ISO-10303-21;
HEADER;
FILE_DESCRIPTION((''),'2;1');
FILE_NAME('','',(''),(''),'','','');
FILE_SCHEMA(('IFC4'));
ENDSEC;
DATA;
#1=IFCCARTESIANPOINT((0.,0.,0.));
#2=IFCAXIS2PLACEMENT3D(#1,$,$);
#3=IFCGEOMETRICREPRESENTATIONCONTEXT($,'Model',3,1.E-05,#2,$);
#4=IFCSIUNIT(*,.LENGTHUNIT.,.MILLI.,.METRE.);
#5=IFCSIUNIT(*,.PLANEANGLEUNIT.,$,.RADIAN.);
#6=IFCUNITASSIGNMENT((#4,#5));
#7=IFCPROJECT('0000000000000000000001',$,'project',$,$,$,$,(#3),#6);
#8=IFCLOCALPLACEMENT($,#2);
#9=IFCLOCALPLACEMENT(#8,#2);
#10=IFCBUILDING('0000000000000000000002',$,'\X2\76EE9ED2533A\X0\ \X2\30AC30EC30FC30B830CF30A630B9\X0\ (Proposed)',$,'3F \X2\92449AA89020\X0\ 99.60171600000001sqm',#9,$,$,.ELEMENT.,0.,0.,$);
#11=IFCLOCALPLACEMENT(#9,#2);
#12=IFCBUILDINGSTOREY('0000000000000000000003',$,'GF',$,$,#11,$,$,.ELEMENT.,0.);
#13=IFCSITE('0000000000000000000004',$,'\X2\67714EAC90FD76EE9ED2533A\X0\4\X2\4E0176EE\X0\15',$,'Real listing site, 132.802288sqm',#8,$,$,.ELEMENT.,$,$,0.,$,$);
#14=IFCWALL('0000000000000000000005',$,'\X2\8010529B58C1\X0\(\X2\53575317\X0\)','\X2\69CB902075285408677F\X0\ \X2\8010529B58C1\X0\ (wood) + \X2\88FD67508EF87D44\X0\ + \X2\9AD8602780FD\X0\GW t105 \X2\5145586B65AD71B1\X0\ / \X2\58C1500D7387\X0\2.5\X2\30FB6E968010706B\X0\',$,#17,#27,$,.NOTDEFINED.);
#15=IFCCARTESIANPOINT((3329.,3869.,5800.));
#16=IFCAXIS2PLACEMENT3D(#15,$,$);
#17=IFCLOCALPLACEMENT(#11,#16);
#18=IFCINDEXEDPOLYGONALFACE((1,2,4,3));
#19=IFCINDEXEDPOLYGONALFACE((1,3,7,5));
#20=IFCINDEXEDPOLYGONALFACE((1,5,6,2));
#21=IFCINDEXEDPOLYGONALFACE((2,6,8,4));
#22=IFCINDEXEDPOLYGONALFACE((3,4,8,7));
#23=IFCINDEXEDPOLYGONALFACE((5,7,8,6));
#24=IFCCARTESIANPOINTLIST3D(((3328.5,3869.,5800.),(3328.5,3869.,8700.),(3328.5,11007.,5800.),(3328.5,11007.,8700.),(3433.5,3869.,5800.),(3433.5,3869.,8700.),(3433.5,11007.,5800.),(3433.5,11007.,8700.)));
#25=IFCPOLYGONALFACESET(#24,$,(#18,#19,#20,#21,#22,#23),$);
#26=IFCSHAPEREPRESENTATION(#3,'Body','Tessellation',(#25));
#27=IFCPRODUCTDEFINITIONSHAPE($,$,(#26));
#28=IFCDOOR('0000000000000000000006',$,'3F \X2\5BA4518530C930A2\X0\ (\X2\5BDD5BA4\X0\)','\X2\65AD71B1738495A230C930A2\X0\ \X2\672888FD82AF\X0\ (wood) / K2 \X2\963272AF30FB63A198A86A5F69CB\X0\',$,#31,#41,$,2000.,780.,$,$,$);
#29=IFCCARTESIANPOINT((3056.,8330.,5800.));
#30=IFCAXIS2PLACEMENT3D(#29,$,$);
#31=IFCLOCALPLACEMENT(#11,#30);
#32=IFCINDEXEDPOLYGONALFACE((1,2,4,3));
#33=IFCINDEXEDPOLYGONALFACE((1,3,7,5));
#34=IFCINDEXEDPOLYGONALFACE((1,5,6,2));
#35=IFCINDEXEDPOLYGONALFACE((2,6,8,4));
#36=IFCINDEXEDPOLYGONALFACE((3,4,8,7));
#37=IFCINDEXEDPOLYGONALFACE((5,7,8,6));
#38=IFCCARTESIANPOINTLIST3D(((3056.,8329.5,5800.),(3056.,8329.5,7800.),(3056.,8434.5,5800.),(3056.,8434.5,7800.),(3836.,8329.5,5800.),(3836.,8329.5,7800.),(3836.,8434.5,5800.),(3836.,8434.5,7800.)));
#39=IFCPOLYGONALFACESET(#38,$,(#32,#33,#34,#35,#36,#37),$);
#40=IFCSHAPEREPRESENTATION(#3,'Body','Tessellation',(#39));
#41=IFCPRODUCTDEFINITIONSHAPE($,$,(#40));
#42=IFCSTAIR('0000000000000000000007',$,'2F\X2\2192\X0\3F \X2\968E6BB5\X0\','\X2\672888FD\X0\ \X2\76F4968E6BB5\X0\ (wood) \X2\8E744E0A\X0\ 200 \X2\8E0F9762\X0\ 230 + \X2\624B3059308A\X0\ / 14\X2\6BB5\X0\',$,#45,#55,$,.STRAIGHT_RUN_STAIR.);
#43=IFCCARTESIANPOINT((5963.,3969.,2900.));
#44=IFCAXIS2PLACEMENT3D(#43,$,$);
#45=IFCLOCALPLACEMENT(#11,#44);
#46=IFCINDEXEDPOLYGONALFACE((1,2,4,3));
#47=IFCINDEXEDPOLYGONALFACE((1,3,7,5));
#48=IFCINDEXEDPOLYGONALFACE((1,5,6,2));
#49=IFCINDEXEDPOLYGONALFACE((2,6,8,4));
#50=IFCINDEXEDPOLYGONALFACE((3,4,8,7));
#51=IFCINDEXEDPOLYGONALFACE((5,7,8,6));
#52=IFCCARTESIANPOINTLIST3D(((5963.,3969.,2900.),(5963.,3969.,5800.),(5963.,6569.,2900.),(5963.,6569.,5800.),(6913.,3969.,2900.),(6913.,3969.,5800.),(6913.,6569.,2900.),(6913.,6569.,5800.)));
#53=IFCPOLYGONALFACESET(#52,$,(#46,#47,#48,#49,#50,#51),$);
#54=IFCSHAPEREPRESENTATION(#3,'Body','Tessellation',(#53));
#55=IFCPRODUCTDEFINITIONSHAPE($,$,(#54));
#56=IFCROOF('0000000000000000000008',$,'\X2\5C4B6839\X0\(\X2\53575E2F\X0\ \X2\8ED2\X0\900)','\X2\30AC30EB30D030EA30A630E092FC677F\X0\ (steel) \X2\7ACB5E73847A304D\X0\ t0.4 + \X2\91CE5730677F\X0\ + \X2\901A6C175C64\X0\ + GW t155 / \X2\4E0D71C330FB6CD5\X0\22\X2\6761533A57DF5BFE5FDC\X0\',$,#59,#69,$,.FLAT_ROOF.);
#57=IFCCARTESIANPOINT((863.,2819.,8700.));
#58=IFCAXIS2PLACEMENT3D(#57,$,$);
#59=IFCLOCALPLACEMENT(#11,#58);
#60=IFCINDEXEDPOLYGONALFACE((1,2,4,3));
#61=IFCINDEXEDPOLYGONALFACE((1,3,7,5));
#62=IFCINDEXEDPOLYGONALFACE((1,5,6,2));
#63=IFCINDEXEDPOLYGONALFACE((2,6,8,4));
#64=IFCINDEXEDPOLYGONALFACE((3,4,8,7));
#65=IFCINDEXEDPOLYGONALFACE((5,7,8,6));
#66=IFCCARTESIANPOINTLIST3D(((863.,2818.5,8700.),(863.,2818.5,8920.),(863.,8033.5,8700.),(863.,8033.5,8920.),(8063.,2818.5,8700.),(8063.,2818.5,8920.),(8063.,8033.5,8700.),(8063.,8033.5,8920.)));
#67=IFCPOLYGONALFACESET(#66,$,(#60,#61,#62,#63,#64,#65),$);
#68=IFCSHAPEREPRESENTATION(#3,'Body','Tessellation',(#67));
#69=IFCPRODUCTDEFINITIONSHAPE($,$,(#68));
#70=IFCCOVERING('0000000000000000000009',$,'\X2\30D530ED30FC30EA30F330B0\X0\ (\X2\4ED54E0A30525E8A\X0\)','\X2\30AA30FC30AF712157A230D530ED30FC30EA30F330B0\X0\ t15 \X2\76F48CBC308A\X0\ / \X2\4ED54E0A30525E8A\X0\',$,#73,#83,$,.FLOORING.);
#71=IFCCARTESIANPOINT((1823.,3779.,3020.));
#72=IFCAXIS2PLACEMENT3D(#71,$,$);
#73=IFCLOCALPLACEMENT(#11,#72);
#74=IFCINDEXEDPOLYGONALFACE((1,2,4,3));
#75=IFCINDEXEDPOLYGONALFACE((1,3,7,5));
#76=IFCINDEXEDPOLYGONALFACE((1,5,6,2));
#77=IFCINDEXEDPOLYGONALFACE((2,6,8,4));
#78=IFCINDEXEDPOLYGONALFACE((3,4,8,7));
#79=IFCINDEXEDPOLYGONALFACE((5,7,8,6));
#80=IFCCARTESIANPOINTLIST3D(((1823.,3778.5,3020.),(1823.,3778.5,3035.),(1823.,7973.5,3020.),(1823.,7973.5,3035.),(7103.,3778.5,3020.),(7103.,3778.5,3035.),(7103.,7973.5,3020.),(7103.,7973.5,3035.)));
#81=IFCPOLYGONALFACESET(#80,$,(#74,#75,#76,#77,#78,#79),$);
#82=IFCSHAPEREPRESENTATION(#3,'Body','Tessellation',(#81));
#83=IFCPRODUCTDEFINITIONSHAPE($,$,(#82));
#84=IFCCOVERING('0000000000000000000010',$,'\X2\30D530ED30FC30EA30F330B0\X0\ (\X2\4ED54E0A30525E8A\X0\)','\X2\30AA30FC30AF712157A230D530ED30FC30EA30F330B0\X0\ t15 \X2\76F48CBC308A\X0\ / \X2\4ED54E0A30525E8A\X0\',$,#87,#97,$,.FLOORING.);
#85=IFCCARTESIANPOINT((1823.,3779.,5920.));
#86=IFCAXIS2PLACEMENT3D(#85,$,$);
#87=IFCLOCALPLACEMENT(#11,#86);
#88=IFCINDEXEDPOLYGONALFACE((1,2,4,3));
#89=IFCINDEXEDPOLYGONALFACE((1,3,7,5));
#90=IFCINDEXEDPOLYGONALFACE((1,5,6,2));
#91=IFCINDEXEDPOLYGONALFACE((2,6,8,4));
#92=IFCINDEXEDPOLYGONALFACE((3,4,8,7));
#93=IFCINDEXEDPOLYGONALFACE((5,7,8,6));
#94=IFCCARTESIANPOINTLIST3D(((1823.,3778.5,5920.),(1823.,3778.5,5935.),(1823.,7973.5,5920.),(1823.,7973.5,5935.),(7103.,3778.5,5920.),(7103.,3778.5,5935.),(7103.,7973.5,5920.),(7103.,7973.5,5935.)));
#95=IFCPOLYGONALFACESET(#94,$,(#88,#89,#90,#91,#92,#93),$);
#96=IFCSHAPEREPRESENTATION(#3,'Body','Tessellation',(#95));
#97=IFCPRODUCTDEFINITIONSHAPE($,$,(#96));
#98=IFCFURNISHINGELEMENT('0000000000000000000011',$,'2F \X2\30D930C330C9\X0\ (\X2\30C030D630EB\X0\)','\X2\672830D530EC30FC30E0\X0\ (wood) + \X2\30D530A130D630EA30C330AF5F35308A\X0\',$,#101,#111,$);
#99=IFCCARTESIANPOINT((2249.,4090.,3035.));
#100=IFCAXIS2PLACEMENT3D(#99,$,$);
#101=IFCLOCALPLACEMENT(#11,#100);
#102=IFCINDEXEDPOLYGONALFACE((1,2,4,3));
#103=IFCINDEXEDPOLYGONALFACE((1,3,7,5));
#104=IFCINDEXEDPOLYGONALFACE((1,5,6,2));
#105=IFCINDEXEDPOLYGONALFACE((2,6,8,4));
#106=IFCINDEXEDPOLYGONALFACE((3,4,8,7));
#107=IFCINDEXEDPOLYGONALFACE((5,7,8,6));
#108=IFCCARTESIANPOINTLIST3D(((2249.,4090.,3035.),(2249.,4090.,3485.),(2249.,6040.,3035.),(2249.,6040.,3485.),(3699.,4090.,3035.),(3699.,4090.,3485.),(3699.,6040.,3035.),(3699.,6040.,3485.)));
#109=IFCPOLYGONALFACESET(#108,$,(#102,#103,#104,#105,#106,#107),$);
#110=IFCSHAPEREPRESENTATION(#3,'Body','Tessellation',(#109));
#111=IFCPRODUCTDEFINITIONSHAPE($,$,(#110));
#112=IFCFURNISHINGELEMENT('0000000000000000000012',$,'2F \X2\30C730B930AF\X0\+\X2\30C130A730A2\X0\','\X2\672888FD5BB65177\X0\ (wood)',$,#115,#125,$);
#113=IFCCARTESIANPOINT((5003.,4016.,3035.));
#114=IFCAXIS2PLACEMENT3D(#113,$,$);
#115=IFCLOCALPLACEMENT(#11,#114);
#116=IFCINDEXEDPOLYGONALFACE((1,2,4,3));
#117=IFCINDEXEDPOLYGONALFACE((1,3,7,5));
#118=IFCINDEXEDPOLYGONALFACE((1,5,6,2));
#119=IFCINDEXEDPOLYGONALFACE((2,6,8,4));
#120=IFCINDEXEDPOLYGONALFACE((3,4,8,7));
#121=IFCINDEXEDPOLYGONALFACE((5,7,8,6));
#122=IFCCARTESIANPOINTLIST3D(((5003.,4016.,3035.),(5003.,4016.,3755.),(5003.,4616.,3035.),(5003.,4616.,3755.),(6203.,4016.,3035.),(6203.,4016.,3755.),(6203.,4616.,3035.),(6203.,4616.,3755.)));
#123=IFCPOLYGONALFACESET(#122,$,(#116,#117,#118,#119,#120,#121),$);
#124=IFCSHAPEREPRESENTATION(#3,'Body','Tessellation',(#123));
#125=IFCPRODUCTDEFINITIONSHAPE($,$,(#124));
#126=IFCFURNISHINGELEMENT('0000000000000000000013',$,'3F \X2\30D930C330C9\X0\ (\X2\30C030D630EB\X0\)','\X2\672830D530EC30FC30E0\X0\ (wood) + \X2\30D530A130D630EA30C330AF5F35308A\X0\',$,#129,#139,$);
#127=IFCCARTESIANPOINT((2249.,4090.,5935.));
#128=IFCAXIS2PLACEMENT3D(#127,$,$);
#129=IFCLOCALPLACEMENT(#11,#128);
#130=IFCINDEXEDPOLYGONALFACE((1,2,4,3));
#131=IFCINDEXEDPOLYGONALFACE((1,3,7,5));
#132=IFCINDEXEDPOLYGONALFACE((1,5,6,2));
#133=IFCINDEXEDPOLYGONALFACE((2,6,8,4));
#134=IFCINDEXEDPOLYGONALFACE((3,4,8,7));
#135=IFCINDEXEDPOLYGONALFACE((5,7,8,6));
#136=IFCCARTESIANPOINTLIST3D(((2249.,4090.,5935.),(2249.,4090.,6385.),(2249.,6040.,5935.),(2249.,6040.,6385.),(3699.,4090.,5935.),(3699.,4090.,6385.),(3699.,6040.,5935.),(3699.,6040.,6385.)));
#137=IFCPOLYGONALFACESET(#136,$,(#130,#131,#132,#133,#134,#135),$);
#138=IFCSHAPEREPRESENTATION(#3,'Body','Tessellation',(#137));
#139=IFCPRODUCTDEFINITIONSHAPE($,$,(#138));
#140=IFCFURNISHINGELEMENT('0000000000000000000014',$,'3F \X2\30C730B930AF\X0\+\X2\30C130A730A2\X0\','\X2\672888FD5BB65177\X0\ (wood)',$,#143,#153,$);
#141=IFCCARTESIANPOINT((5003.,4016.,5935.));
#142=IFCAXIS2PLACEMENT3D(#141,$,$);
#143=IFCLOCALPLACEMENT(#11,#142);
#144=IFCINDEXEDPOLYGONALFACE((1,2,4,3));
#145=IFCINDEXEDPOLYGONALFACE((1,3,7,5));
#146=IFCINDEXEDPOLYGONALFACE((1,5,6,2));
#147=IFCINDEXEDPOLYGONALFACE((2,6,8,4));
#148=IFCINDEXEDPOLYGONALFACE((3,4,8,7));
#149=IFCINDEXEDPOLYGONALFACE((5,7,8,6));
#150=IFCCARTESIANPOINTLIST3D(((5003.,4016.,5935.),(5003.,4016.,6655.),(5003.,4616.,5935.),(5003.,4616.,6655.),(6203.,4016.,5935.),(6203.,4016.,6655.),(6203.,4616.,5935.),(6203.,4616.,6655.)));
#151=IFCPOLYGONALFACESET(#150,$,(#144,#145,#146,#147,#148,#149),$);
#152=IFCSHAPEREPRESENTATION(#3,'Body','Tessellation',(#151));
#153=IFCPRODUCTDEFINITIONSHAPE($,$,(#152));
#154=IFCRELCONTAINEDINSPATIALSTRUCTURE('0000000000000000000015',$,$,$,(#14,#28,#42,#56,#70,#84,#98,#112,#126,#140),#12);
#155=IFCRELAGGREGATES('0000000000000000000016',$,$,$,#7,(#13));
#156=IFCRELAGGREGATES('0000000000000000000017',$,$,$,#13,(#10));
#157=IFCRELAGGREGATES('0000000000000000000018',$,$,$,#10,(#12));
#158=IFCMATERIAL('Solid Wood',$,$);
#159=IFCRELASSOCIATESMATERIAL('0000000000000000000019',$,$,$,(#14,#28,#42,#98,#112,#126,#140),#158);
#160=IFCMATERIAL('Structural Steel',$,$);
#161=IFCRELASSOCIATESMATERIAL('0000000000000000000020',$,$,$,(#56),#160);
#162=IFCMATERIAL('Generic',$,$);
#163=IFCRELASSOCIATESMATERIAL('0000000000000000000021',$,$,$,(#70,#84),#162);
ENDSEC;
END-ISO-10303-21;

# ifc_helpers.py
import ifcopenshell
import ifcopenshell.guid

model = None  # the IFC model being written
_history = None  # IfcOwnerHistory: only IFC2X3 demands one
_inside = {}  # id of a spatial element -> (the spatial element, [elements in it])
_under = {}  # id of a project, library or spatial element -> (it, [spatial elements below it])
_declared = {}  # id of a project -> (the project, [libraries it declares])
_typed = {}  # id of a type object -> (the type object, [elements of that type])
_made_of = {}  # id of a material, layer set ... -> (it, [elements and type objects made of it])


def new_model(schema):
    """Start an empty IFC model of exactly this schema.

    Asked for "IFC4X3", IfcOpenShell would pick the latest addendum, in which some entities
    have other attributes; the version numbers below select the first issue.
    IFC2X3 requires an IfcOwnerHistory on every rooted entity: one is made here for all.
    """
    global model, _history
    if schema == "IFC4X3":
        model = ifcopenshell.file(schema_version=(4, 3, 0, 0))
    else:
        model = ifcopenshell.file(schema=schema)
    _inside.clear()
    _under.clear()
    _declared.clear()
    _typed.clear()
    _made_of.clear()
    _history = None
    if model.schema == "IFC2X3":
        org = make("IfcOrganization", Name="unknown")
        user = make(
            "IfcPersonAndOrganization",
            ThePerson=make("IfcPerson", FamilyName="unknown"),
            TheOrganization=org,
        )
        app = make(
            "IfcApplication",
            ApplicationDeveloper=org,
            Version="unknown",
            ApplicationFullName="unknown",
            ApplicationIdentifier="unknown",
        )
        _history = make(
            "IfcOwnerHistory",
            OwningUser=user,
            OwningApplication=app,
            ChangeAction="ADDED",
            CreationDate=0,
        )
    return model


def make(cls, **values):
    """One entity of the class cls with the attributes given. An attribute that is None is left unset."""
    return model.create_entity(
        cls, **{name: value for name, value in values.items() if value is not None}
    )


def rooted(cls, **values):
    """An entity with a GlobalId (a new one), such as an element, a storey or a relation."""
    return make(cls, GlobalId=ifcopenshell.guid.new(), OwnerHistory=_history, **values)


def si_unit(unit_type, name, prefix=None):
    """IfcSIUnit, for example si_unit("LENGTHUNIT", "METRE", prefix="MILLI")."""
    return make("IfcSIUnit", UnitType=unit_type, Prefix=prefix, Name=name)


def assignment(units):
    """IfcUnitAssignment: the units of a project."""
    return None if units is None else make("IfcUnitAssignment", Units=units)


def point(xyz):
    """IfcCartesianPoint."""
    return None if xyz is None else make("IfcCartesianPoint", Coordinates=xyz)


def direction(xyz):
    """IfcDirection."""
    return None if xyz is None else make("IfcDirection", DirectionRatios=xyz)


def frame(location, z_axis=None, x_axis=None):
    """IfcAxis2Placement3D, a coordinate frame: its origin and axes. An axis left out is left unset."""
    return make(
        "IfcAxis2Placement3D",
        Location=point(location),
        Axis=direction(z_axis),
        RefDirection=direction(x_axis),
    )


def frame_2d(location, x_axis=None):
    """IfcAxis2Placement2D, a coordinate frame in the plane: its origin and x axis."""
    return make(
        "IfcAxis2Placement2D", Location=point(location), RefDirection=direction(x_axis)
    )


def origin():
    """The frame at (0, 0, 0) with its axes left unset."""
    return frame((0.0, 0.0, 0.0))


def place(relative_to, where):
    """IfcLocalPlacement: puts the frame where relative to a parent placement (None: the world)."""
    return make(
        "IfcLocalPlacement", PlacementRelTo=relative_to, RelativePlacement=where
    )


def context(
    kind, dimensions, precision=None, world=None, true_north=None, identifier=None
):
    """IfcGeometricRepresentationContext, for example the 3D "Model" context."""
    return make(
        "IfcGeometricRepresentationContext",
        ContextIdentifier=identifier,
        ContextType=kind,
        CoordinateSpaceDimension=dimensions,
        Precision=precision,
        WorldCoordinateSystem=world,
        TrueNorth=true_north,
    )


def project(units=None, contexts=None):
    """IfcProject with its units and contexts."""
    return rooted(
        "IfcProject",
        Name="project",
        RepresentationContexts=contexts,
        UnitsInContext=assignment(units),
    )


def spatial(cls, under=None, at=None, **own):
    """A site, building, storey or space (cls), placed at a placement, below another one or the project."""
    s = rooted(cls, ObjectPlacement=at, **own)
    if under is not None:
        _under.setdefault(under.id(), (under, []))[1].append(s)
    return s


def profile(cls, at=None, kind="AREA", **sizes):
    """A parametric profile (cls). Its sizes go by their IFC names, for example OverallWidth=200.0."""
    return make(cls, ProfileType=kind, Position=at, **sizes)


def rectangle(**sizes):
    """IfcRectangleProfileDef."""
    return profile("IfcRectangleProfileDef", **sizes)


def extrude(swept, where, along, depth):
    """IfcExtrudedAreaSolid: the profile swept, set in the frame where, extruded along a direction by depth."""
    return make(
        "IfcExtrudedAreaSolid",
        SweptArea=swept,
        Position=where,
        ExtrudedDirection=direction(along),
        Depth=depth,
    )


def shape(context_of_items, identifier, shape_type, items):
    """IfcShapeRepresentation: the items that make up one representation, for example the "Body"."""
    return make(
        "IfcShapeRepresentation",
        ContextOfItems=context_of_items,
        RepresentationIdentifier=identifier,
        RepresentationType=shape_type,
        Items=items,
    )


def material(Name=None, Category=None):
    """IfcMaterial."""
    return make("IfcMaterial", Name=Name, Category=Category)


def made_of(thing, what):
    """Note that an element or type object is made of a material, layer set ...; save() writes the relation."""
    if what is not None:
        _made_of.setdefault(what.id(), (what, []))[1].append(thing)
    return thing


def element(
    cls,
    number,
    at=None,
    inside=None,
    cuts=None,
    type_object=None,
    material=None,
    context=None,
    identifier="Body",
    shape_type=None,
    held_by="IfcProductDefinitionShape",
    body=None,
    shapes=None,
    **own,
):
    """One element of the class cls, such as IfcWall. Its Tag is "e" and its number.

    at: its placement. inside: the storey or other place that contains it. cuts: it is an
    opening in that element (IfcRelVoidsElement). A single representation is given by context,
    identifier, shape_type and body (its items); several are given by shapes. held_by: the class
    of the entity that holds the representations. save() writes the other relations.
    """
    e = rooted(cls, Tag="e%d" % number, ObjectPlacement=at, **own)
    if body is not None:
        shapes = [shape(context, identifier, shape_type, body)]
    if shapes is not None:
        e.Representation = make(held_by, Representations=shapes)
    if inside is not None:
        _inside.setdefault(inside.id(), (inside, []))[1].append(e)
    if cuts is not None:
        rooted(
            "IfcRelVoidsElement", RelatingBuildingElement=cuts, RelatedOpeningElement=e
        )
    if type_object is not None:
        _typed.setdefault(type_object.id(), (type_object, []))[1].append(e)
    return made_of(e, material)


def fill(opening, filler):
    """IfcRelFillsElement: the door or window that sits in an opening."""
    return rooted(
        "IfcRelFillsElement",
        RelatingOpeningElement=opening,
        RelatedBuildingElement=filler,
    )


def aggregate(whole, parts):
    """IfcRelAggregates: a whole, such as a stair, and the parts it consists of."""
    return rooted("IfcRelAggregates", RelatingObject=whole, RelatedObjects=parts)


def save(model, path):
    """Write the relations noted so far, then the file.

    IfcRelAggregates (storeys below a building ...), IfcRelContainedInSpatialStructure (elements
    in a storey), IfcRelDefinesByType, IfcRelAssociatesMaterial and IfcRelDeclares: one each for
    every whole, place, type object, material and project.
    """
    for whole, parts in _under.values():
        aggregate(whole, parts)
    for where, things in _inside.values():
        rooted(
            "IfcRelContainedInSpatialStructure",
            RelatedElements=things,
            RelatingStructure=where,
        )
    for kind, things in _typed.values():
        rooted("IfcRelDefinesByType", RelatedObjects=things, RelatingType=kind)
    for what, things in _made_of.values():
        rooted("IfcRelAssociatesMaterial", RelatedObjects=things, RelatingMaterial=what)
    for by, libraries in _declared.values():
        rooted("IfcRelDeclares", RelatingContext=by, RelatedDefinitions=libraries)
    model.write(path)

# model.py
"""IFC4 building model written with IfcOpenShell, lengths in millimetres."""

from ifc_helpers import new_model, si_unit, frame, frame_2d, origin, place, context, project, spatial, rectangle, extrude, material, element, fill, save


model = new_model("IFC4")

# Units and contexts
model_context = context("Model", 3, precision=1e-05, world=origin())
ifc_project = project(units=[si_unit("LENGTHUNIT", "METRE", prefix="MILLI"), si_unit("PLANEANGLEUNIT", "RADIAN")], contexts=[model_context])

# Site, building, storey
site_placement = place(None, origin())
site = spatial("IfcSite", under=ifc_project, at=site_placement, Name="東京都目黒区4丁目15", ObjectType="Real listing site, 132.802288sqm", CompositionType="ELEMENT", RefElevation=0.0)
building_placement = place(site_placement, origin())
building = spatial("IfcBuilding", under=site, at=building_placement, Name="目黒区 ガレージハウス (Proposed)", ObjectType="3F 鉄骨造 99.60171600000001sqm", CompositionType="ELEMENT", ElevationOfRefHeight=0.0, ElevationOfTerrain=0.0)
storey_placement = place(building_placement, origin())
storey = spatial("IfcBuildingStorey", under=building, at=storey_placement, Name="GF", CompositionType="ELEMENT", Elevation=0.0)

# Shared definitions
ifc_material_1 = material(Name="Solid Wood")

# Wall, opening, door
wall_1_placement = place(storey_placement, frame((3329.0, 3869.0, 5800.0)))
wall_1 = element("IfcWall", 1, at=wall_1_placement, inside=storey, material=ifc_material_1, Name="耐力壁(南北)", Description="構造用合板 耐力壁 (wood) + 製材軸組 + 高性能GW t105 充填断熱 / 壁倍率2.5・準耐火", PredefinedType="NOTDEFINED", context=model_context, shape_type="SweptSolid", body=[
    extrude(rectangle(XDim=105.0, YDim=7138.0, at=frame_2d((52.0, 3569.0))), frame((3329.0, 3869.0, 5800.0)), (0.0, 0.0, 1.0), 2900.0),
])
opening_1_placement = place(storey_placement, frame((3056.0, 8330.0, 5800.0)))
opening_1 = element("IfcOpeningElement", 2, at=opening_1_placement, cuts=wall_1, PredefinedType="NOTDEFINED", context=model_context, shape_type="SweptSolid", body=[
    extrude(rectangle(XDim=780.0, YDim=105.0, at=frame_2d((390.0, 52.0))), frame((3056.0, 8330.0, 5800.0)), (0.0, 0.0, 1.0), 2000.0),
])
door_1_placement = place(storey_placement, frame((3056.0, 8330.0, 5800.0)))
door_1 = element("IfcDoor", 3, at=door_1_placement, inside=storey, material=ifc_material_1, Name="3F 室内ドア (寝室)", Description="断熱玄関ドア 木製芯 (wood) / K2 防犯・採風機構", OverallHeight=2000.0, OverallWidth=780.0, context=model_context, shape_type="SweptSolid", body=[
    extrude(rectangle(XDim=780.0, YDim=105.0, at=frame_2d((390.0, 52.0))), frame((3056.0, 8330.0, 5800.0)), (0.0, 0.0, 1.0), 2000.0),
])
fill(opening_1, door_1)

# Stair
stair_placement = place(storey_placement, frame((5963.0, 3969.0, 2900.0)))
element("IfcStair", 4, at=stair_placement, inside=storey, material=ifc_material_1, Name="2F→3F 階段", Description="木製 直階段 (wood) 蹴上 200 踏面 230 + 手すり / 14段", PredefinedType="STRAIGHT_RUN_STAIR", context=model_context, shape_type="SweptSolid", body=[
    extrude(rectangle(XDim=950.0, YDim=2600.0, at=frame_2d((475.0, 1300.0))), frame((5963.0, 3969.0, 2900.0)), (0.0, 0.0, 1.0), 2900.0),
])

# Roof
ifc_material_2 = material(Name="Structural Steel")
for number, where, name in (
    (5, (863.0, 2819.0, 8700.0), "屋根(南帯 軒900)"),
):
    element("IfcRoof", number, at=place(storey_placement, frame(where)), inside=storey, material=ifc_material_2, Name=name, Description="ガルバリウム鋼板 (steel) 立平葺き t0.4 + 野地板 + 通気層 + GW t155 / 不燃・法22条区域対応", PredefinedType="FLAT_ROOF", context=model_context, shape_type="SweptSolid", body=[
        extrude(rectangle(XDim=7200.0, YDim=5215.0, at=frame_2d((3600.0, 2607.0))), frame((863.0, 2819.0, 8700.0)), (0.0, 0.0, 1.0), 220.0),
    ])

# Coverings
ifc_material_3 = material(Name="Generic")
covering_1_placement = place(storey_placement, frame((1823.0, 3779.0, 3020.0)))
element("IfcCovering", 6, at=covering_1_placement, inside=storey, material=ifc_material_3, Name="フローリング (仕上げ床)", Description="オーク無垢フローリング t15 直貼り / 仕上げ床", PredefinedType="FLOORING", context=model_context, shape_type="SweptSolid", body=[
    extrude(rectangle(XDim=5280.0, YDim=4195.0, at=frame_2d((2640.0, 2097.0))), frame((1823.0, 3779.0, 3020.0)), (0.0, 0.0, 1.0), 15.0),
])
covering_2_placement = place(storey_placement, frame((1823.0, 3779.0, 5920.0)))
element("IfcCovering", 7, at=covering_2_placement, inside=storey, material=ifc_material_3, Name="フローリング (仕上げ床)", Description="オーク無垢フローリング t15 直貼り / 仕上げ床", PredefinedType="FLOORING", context=model_context, shape_type="SweptSolid", body=[
    extrude(rectangle(XDim=5280.0, YDim=4195.0, at=frame_2d((2640.0, 2097.0))), frame((1823.0, 3779.0, 5920.0)), (0.0, 0.0, 1.0), 15.0),
])

# Furnishing elements
furnishing_1_placement = place(storey_placement, frame((2249.0, 4090.0, 3035.0)))
element("IfcFurnishingElement", 8, at=furnishing_1_placement, inside=storey, material=ifc_material_1, Name="2F ベッド (ダブル)", Description="木フレーム (wood) + ファブリック張り", context=model_context, shape_type="SweptSolid", body=[
    extrude(rectangle(XDim=1450.0, YDim=1950.0, at=frame_2d((725.0, 975.0))), frame((2249.0, 4090.0, 3035.0)), (0.0, 0.0, 1.0), 450.0),
])
furnishing_2_placement = place(storey_placement, frame((5003.0, 4016.0, 3035.0)))
element("IfcFurnishingElement", 9, at=furnishing_2_placement, inside=storey, material=ifc_material_1, Name="2F デスク+チェア", Description="木製家具 (wood)", context=model_context, shape_type="SweptSolid", body=[
    extrude(rectangle(XDim=1200.0, YDim=600.0, at=frame_2d((600.0, 300.0))), frame((5003.0, 4016.0, 3035.0)), (0.0, 0.0, 1.0), 720.0),
])
furnishing_3_placement = place(storey_placement, frame((2249.0, 4090.0, 5935.0)))
element("IfcFurnishingElement", 10, at=furnishing_3_placement, inside=storey, material=ifc_material_1, Name="3F ベッド (ダブル)", Description="木フレーム (wood) + ファブリック張り", context=model_context, shape_type="SweptSolid", body=[
    extrude(rectangle(XDim=1450.0, YDim=1950.0, at=frame_2d((725.0, 975.0))), frame((2249.0, 4090.0, 5935.0)), (0.0, 0.0, 1.0), 450.0),
])
furnishing_4_placement = place(storey_placement, frame((5003.0, 4016.0, 5935.0)))
element("IfcFurnishingElement", 11, at=furnishing_4_placement, inside=storey, material=ifc_material_1, Name="3F デスク+チェア", Description="木製家具 (wood)", context=model_context, shape_type="SweptSolid", body=[
    extrude(rectangle(XDim=1200.0, YDim=600.0, at=frame_2d((600.0, 300.0))), frame((5003.0, 4016.0, 5935.0)), (0.0, 0.0, 1.0), 720.0),
])

save(model, "model.ifc")
